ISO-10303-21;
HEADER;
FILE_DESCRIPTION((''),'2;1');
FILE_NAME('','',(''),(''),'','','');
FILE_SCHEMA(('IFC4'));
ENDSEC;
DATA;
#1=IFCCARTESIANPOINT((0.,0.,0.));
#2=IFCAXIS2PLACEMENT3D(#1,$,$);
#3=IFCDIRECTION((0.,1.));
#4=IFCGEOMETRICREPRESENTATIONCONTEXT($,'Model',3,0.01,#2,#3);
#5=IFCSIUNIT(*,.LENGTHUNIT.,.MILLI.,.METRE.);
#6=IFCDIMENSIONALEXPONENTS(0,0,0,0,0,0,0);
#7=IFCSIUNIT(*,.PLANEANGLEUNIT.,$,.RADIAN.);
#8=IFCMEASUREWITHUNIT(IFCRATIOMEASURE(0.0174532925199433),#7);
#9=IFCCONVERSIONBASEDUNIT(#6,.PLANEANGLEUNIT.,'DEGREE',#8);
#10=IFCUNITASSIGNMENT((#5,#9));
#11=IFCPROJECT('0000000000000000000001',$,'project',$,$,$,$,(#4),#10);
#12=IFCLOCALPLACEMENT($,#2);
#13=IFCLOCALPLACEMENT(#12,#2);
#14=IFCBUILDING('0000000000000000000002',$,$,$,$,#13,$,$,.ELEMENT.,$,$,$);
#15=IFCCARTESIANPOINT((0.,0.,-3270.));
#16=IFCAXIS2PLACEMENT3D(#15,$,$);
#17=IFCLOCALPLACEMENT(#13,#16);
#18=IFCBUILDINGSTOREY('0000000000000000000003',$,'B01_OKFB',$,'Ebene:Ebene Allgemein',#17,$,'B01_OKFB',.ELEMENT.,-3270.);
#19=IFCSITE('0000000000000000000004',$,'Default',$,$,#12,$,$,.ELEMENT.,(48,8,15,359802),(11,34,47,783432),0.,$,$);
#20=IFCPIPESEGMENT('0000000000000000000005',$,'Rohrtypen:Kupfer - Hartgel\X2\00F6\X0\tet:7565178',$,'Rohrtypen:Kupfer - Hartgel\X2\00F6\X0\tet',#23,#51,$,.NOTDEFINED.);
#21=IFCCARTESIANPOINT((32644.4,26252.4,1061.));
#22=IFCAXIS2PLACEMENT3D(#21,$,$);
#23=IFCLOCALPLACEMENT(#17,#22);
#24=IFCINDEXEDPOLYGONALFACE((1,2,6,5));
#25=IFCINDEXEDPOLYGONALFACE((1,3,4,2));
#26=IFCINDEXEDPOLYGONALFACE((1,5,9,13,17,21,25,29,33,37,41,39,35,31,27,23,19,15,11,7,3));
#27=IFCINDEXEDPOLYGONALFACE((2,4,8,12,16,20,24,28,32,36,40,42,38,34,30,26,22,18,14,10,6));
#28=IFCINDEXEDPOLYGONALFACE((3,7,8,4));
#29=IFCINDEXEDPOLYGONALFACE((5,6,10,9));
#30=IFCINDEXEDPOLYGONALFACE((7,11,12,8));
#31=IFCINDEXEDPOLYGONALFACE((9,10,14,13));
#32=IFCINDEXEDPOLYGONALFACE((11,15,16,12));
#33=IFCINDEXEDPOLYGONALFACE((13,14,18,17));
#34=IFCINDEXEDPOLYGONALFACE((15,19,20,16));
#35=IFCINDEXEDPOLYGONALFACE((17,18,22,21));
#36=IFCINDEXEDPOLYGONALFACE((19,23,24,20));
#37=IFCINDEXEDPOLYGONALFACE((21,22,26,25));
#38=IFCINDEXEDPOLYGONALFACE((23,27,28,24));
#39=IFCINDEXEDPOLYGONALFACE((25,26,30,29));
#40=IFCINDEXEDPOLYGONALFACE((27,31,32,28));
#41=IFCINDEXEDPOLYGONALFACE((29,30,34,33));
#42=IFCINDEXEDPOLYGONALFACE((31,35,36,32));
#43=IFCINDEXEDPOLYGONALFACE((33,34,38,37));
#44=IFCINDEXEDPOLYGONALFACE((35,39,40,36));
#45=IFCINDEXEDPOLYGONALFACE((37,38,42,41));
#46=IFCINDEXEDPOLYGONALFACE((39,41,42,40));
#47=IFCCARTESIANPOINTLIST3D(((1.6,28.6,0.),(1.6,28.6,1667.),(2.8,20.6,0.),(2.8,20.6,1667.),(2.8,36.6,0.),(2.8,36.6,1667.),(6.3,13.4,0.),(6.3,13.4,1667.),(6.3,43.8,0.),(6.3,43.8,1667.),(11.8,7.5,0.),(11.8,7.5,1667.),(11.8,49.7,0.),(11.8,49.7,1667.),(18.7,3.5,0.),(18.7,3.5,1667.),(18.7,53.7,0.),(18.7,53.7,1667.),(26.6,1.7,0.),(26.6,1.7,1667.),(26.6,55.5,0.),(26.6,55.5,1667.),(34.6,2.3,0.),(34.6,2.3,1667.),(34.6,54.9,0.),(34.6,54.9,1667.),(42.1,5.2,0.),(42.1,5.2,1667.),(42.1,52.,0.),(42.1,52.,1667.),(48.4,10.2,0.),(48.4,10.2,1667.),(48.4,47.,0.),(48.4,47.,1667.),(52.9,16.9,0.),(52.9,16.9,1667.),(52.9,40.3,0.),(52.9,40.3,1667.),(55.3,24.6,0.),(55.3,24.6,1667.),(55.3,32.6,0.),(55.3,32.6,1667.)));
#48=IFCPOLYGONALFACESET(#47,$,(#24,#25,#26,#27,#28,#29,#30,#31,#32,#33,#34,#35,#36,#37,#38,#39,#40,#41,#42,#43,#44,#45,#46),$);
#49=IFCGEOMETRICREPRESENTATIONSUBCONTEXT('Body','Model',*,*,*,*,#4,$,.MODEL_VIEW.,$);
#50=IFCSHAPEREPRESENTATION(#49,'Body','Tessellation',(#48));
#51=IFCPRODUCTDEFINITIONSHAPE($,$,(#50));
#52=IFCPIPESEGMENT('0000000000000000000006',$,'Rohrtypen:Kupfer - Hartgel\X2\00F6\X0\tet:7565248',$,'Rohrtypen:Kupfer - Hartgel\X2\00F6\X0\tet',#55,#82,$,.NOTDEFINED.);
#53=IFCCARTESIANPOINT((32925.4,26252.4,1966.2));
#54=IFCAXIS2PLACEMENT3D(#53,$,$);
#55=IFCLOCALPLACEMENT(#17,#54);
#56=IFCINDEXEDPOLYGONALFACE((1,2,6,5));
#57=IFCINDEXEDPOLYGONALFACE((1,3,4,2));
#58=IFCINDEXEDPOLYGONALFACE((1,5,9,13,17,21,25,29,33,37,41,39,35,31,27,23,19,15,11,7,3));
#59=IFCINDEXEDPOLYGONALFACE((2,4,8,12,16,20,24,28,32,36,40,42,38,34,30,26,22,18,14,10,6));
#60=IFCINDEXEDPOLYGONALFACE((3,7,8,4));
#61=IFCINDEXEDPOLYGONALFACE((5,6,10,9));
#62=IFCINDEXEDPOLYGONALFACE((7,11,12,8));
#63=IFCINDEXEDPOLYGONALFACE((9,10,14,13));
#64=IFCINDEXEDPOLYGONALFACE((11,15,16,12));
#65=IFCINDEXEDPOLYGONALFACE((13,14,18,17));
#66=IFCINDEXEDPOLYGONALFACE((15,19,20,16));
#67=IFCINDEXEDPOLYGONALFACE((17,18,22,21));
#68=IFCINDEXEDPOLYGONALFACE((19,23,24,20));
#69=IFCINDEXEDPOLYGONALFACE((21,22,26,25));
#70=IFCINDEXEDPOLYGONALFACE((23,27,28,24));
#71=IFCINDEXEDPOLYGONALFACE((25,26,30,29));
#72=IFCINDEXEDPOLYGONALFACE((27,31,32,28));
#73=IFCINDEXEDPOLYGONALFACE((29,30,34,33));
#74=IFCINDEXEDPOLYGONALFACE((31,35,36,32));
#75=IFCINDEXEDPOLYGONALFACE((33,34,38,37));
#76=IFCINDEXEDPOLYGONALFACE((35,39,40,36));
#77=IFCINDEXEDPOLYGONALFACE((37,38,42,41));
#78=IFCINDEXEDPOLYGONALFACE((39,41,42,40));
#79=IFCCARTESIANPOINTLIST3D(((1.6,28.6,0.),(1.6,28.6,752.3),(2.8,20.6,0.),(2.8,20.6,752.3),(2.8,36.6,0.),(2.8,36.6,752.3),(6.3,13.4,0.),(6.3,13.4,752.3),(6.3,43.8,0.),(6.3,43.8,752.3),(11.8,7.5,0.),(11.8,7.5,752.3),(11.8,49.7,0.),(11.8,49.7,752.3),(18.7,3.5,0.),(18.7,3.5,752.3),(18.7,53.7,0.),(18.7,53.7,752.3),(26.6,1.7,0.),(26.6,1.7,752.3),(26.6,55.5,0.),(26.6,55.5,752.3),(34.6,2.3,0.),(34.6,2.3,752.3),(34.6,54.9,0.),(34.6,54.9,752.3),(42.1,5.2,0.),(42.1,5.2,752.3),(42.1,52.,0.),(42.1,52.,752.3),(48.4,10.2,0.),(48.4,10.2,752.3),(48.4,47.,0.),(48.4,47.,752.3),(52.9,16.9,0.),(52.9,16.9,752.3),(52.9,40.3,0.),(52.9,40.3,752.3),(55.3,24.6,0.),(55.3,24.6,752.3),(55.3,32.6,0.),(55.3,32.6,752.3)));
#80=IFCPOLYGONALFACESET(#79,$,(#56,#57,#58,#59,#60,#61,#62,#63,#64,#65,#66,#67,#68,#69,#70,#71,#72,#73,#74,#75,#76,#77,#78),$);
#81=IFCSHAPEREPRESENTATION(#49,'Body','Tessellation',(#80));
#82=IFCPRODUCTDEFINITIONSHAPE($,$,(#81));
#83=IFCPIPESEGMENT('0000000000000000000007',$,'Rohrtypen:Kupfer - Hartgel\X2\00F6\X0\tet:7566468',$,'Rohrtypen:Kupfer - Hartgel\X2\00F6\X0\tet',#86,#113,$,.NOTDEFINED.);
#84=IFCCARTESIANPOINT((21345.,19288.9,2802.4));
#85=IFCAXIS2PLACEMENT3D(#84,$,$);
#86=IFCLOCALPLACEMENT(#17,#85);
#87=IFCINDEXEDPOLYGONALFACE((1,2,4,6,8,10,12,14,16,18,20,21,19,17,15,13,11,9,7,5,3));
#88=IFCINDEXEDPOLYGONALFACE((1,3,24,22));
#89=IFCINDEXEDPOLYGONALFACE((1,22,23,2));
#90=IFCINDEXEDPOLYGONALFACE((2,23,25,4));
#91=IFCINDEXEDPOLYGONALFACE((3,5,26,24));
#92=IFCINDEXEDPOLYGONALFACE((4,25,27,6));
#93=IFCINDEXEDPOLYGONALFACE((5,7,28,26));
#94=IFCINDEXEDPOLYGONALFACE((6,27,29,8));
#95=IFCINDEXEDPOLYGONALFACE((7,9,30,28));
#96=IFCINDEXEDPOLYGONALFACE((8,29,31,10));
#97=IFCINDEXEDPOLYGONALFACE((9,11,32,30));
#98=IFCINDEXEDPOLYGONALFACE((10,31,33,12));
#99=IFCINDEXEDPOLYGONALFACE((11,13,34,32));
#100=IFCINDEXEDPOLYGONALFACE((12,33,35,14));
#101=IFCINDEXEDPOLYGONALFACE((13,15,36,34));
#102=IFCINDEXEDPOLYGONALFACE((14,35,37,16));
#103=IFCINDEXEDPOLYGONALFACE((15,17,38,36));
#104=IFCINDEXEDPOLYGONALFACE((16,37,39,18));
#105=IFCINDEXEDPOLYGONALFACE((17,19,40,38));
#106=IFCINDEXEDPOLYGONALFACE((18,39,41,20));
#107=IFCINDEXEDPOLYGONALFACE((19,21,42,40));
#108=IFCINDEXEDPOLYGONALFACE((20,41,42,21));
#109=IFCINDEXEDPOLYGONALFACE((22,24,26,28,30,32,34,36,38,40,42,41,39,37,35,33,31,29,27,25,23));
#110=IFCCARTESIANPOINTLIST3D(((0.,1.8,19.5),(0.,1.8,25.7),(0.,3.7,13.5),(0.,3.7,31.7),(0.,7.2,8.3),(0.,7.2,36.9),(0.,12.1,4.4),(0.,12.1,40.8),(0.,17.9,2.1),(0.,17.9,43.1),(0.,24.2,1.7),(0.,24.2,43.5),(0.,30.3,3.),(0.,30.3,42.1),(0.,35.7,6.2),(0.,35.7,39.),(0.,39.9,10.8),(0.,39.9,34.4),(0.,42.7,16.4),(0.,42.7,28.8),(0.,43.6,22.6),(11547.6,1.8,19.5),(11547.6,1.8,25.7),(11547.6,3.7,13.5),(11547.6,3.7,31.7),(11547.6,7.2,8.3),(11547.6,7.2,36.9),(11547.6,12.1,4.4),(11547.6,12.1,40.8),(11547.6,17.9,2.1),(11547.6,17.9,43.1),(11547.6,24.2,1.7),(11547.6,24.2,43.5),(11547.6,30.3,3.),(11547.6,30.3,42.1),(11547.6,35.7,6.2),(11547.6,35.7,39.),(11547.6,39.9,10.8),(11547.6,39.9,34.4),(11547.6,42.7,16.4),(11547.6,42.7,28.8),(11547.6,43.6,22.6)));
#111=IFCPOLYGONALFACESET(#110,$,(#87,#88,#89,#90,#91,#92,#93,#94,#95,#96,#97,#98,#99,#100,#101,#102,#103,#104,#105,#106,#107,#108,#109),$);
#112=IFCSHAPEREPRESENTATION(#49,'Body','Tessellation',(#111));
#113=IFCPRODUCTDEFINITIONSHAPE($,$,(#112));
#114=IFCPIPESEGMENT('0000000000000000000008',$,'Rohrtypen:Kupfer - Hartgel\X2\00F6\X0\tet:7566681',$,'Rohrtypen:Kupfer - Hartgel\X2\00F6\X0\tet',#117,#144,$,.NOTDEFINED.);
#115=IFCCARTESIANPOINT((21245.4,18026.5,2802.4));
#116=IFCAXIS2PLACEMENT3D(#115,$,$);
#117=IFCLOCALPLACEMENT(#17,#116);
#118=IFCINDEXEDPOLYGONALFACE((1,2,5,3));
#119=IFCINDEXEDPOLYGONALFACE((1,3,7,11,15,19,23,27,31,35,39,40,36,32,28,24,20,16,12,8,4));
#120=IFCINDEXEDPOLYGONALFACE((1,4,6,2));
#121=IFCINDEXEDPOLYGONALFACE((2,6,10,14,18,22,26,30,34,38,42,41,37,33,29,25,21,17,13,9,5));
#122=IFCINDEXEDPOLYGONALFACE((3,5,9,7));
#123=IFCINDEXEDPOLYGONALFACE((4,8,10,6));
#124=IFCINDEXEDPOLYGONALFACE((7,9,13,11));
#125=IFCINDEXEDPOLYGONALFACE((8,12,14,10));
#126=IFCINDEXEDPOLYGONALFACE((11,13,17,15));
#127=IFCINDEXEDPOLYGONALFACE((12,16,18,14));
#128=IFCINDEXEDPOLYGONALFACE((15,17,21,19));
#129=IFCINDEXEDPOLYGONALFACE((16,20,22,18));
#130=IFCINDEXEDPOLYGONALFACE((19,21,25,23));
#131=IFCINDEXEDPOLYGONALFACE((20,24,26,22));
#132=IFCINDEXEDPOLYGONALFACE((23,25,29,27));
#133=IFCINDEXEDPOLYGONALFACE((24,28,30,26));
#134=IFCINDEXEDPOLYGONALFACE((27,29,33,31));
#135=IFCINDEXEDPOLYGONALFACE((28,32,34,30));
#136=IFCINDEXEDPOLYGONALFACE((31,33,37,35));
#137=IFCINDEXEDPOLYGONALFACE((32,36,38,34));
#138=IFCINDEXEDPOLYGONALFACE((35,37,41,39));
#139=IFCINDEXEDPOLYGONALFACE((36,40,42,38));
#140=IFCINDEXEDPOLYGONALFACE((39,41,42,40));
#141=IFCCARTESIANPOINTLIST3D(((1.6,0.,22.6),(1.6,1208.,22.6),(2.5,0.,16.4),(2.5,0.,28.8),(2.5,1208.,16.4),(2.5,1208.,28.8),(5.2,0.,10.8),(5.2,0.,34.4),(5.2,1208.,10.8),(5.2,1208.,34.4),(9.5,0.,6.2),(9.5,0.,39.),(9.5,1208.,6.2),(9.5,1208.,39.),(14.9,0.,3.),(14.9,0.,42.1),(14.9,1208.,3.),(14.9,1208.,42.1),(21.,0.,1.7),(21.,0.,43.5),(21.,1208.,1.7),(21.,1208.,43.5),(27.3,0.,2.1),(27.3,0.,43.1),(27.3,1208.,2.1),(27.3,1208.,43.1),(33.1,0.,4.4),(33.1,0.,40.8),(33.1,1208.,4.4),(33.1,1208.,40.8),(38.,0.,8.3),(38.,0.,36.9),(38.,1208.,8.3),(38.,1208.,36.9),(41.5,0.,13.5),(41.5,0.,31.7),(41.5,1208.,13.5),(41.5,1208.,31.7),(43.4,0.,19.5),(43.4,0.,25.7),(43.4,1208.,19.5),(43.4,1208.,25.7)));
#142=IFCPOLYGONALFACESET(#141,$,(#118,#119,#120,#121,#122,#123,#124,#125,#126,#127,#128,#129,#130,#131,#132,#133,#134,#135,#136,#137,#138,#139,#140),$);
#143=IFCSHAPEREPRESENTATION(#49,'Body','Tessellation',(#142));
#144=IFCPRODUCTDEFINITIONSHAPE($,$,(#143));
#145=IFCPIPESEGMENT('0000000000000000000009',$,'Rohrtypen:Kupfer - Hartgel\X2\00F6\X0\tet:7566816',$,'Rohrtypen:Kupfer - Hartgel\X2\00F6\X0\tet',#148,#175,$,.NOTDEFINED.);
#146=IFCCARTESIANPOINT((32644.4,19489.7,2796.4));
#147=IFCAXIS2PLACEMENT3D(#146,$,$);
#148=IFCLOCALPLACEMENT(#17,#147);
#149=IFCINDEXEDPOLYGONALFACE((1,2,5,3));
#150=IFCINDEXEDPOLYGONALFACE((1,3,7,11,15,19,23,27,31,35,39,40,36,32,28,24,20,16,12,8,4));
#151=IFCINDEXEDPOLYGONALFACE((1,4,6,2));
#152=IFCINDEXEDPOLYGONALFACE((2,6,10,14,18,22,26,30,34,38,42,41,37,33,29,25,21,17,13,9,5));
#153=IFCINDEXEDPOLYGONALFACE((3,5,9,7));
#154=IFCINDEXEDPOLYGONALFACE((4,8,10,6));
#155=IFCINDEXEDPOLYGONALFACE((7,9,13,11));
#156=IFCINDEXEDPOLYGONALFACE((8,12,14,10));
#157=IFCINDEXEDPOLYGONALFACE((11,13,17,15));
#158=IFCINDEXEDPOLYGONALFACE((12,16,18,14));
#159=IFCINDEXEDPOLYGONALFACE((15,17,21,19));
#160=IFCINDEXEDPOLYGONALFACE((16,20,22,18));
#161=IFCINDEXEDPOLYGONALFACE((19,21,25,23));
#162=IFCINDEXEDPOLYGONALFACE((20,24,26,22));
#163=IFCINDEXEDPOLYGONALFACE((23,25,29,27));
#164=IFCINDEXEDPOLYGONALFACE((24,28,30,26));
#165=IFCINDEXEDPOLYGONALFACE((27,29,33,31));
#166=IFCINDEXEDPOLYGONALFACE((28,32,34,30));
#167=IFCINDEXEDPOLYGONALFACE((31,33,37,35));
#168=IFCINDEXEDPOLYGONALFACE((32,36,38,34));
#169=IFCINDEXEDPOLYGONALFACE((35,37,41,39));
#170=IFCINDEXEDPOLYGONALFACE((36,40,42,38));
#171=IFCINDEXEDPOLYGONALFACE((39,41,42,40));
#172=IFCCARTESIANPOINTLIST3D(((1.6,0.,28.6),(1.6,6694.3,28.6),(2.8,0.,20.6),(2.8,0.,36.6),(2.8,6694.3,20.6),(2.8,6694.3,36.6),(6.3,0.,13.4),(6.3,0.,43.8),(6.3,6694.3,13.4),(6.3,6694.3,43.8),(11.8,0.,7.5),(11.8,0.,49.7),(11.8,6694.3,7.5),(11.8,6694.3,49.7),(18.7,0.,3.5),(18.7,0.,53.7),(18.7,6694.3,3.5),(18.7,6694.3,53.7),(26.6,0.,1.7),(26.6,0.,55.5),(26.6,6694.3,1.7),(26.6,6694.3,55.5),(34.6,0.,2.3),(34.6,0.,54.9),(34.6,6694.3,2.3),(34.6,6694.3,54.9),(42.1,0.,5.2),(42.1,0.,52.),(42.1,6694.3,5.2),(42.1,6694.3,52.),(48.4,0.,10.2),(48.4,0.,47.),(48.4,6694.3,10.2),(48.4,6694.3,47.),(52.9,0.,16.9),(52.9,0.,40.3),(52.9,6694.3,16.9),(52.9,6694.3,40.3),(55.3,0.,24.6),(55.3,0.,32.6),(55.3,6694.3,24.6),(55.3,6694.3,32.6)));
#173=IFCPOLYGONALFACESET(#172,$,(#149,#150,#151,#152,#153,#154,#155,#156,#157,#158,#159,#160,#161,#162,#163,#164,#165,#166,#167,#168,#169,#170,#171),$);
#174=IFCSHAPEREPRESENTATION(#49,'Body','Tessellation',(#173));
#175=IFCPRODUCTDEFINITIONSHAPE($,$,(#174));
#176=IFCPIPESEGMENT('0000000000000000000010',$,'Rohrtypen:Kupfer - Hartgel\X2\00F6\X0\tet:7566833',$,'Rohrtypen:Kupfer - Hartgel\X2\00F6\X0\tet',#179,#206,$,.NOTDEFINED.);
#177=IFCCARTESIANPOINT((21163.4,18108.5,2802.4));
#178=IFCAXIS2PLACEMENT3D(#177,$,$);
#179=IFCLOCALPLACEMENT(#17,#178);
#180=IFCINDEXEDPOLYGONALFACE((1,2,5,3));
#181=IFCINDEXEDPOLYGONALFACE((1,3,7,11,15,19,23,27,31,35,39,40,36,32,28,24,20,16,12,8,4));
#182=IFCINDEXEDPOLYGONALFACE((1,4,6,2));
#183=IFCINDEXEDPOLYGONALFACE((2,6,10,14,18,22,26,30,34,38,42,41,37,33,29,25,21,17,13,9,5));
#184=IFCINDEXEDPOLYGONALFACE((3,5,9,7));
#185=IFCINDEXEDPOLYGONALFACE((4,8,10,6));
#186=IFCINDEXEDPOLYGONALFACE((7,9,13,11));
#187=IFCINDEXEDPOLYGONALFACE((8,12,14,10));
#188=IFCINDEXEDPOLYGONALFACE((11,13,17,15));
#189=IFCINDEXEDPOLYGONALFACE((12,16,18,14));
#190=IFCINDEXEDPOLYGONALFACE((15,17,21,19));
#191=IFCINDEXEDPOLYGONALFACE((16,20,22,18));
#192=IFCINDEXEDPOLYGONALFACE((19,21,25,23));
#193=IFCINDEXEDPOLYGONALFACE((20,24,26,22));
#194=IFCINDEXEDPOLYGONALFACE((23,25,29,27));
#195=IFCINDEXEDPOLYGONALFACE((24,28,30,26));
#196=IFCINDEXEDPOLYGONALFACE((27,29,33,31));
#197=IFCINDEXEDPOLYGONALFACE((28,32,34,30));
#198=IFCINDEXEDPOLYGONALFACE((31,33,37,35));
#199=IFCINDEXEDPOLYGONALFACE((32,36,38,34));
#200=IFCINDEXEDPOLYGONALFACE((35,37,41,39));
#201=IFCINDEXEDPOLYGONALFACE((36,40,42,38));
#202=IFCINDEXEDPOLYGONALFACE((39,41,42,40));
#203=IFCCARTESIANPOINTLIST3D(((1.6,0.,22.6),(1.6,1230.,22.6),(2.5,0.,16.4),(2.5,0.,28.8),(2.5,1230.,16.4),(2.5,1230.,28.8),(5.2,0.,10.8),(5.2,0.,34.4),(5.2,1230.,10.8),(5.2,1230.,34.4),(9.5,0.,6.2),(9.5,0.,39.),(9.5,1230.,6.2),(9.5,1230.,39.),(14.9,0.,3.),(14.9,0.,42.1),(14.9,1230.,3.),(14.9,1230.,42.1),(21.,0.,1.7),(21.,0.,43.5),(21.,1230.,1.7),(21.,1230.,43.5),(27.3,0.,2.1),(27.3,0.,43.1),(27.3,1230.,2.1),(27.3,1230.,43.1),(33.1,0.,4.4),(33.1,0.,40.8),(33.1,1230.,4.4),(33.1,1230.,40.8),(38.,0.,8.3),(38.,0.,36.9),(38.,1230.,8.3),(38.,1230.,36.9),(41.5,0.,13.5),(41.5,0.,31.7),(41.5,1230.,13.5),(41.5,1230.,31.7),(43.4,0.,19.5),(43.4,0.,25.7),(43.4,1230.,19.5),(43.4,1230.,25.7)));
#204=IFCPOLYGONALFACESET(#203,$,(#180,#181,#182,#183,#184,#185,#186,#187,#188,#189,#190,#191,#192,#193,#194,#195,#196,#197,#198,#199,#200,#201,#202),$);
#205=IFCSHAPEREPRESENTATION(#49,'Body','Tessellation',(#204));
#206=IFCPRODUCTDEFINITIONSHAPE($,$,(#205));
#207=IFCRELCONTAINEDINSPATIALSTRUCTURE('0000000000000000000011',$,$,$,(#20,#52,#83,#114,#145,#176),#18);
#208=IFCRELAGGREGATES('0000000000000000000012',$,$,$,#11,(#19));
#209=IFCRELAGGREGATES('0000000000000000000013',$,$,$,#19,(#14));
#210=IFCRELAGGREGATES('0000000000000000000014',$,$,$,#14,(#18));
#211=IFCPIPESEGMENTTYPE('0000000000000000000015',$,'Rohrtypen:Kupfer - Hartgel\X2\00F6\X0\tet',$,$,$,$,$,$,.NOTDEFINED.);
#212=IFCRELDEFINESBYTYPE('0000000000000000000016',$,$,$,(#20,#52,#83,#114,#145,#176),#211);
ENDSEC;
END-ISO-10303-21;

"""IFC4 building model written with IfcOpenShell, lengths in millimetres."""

from ifc_helpers import new_model, entity, si_unit, converted_unit, direction, frame, frame_2d, origin, origin_2d_with_axis, place, context, subcontext, project, spatial, circle, extrude, type_object, element, save


model = new_model("IFC4")

# Units and contexts
model_context = context("Model", 3, precision=0.01, world=origin(), true_north=direction((0.0, 1.0)))
body_context = subcontext(model_context, "Body", "Model", "MODEL_VIEW")
ifc_project = project(units=[si_unit("LENGTHUNIT", "METRE", prefix="MILLI"), converted_unit("PLANEANGLEUNIT", "DEGREE", entity("IfcRatioMeasure", 0.0174532925199433), si_unit("PLANEANGLEUNIT", "RADIAN"), dimensions=[0, 0, 0, 0, 0, 0, 0])], contexts=[model_context])

# Site, building, storey
site_placement = place(None, origin())
site = spatial("IfcSite", under=ifc_project, at=site_placement, Name="Default", CompositionType="ELEMENT", RefLatitude=(48, 8, 15, 359802), RefLongitude=(11, 34, 47, 783432), RefElevation=0.0)
building_placement = place(site_placement, origin())
building = spatial("IfcBuilding", under=site, at=building_placement, CompositionType="ELEMENT")
storey_placement = place(building_placement, frame((0.0, 0.0, -3270.0)))
storey = spatial("IfcBuildingStorey", under=building, at=storey_placement, Name="B01_OKFB", ObjectType="Ebene:Ebene Allgemein", LongName="B01_OKFB", CompositionType="ELEMENT", Elevation=-3270.0)

# Pipe segments
pipe_segment_type = type_object("IfcPipeSegmentType", Name="Rohrtypen:Kupfer - Hartgelötet", PredefinedType="NOTDEFINED")
pipe_segment_1_placement = place(storey_placement, frame((32644.4, 26252.4, 1061.0)))
element("IfcPipeSegment", 1, at=pipe_segment_1_placement, inside=storey, type_object=pipe_segment_type, Name="Rohrtypen:Kupfer - Hartgelötet:7565178", ObjectType="Rohrtypen:Kupfer - Hartgelötet", PredefinedType="NOTDEFINED", context=body_context, shape_type="SweptSolid", body=[
    extrude(circle(Radius=27.0, at=frame_2d((0.0, 0.0), x_axis=(1.0, 0.0))), frame((28.6, 28.6, 0.0), z_axis=(0.0, 0.0, 1.0), x_axis=(-1.0, 0.0, 0.0)), (0.0, 0.0, 1.0), 1667.0),
])
pipe_segment_2_placement = place(storey_placement, frame((32925.4, 26252.4, 1966.2)))
element("IfcPipeSegment", 2, at=pipe_segment_2_placement, inside=storey, type_object=pipe_segment_type, Name="Rohrtypen:Kupfer - Hartgelötet:7565248", ObjectType="Rohrtypen:Kupfer - Hartgelötet", PredefinedType="NOTDEFINED", context=body_context, shape_type="SweptSolid", body=[
    extrude(circle(Radius=27.0, at=origin_2d_with_axis()), frame((28.6, 28.6, 0.0), z_axis=(0.0, 0.0, 1.0), x_axis=(-1.0, 0.0, 0.0)), (0.0, 0.0, 1.0), 752.3),
])
pipe_segment_3_placement = place(storey_placement, frame((21345.0, 19288.9, 2802.4)))
element("IfcPipeSegment", 3, at=pipe_segment_3_placement, inside=storey, type_object=pipe_segment_type, Name="Rohrtypen:Kupfer - Hartgelötet:7566468", ObjectType="Rohrtypen:Kupfer - Hartgelötet", PredefinedType="NOTDEFINED", context=body_context, shape_type="SweptSolid", body=[
    extrude(circle(Radius=21.0, at=frame_2d((0.0, 0.0), x_axis=(1.0, 0.0))), frame((0.0, 22.6, 22.6), z_axis=(1.0, 0.0, 0.0), x_axis=(0.0, 1.0, 0.0)), (0.0, 0.0, 1.0), 11547.6),
])
pipe_segment_4_placement = place(storey_placement, frame((21245.4, 18026.5, 2802.4)))
element("IfcPipeSegment", 4, at=pipe_segment_4_placement, inside=storey, type_object=pipe_segment_type, Name="Rohrtypen:Kupfer - Hartgelötet:7566681", ObjectType="Rohrtypen:Kupfer - Hartgelötet", PredefinedType="NOTDEFINED", context=body_context, shape_type="SweptSolid", body=[
    extrude(circle(Radius=21.0, at=origin_2d_with_axis()), frame((22.6, 0.0, 22.6), z_axis=(0.0, 1.0, 0.0), x_axis=(-1.0, 0.0, 0.0)), (0.0, 0.0, 1.0), 1208.0),
])
pipe_segment_5_placement = place(storey_placement, frame((32644.4, 19489.7, 2796.4)))
element("IfcPipeSegment", 5, at=pipe_segment_5_placement, inside=storey, type_object=pipe_segment_type, Name="Rohrtypen:Kupfer - Hartgelötet:7566816", ObjectType="Rohrtypen:Kupfer - Hartgelötet", PredefinedType="NOTDEFINED", context=body_context, shape_type="SweptSolid", body=[
    extrude(circle(Radius=27.0, at=origin_2d_with_axis()), frame((28.6, 0.0, 28.6), z_axis=(0.0, 1.0, 0.0), x_axis=(-1.0, 0.0, 0.0)), (0.0, 0.0, 1.0), 6694.3),
])
pipe_segment_6_placement = place(storey_placement, frame((21163.4, 18108.5, 2802.4)))
element("IfcPipeSegment", 6, at=pipe_segment_6_placement, inside=storey, type_object=pipe_segment_type, Name="Rohrtypen:Kupfer - Hartgelötet:7566833", ObjectType="Rohrtypen:Kupfer - Hartgelötet", PredefinedType="NOTDEFINED", context=body_context, shape_type="SweptSolid", body=[
    extrude(circle(Radius=21.0, at=origin_2d_with_axis()), frame((22.6, 0.0, 22.6), z_axis=(0.0, 1.0, 0.0), x_axis=(-1.0, 0.0, 0.0)), (0.0, 0.0, 1.0), 1230.0),
])

save(model, "model.ifc")
